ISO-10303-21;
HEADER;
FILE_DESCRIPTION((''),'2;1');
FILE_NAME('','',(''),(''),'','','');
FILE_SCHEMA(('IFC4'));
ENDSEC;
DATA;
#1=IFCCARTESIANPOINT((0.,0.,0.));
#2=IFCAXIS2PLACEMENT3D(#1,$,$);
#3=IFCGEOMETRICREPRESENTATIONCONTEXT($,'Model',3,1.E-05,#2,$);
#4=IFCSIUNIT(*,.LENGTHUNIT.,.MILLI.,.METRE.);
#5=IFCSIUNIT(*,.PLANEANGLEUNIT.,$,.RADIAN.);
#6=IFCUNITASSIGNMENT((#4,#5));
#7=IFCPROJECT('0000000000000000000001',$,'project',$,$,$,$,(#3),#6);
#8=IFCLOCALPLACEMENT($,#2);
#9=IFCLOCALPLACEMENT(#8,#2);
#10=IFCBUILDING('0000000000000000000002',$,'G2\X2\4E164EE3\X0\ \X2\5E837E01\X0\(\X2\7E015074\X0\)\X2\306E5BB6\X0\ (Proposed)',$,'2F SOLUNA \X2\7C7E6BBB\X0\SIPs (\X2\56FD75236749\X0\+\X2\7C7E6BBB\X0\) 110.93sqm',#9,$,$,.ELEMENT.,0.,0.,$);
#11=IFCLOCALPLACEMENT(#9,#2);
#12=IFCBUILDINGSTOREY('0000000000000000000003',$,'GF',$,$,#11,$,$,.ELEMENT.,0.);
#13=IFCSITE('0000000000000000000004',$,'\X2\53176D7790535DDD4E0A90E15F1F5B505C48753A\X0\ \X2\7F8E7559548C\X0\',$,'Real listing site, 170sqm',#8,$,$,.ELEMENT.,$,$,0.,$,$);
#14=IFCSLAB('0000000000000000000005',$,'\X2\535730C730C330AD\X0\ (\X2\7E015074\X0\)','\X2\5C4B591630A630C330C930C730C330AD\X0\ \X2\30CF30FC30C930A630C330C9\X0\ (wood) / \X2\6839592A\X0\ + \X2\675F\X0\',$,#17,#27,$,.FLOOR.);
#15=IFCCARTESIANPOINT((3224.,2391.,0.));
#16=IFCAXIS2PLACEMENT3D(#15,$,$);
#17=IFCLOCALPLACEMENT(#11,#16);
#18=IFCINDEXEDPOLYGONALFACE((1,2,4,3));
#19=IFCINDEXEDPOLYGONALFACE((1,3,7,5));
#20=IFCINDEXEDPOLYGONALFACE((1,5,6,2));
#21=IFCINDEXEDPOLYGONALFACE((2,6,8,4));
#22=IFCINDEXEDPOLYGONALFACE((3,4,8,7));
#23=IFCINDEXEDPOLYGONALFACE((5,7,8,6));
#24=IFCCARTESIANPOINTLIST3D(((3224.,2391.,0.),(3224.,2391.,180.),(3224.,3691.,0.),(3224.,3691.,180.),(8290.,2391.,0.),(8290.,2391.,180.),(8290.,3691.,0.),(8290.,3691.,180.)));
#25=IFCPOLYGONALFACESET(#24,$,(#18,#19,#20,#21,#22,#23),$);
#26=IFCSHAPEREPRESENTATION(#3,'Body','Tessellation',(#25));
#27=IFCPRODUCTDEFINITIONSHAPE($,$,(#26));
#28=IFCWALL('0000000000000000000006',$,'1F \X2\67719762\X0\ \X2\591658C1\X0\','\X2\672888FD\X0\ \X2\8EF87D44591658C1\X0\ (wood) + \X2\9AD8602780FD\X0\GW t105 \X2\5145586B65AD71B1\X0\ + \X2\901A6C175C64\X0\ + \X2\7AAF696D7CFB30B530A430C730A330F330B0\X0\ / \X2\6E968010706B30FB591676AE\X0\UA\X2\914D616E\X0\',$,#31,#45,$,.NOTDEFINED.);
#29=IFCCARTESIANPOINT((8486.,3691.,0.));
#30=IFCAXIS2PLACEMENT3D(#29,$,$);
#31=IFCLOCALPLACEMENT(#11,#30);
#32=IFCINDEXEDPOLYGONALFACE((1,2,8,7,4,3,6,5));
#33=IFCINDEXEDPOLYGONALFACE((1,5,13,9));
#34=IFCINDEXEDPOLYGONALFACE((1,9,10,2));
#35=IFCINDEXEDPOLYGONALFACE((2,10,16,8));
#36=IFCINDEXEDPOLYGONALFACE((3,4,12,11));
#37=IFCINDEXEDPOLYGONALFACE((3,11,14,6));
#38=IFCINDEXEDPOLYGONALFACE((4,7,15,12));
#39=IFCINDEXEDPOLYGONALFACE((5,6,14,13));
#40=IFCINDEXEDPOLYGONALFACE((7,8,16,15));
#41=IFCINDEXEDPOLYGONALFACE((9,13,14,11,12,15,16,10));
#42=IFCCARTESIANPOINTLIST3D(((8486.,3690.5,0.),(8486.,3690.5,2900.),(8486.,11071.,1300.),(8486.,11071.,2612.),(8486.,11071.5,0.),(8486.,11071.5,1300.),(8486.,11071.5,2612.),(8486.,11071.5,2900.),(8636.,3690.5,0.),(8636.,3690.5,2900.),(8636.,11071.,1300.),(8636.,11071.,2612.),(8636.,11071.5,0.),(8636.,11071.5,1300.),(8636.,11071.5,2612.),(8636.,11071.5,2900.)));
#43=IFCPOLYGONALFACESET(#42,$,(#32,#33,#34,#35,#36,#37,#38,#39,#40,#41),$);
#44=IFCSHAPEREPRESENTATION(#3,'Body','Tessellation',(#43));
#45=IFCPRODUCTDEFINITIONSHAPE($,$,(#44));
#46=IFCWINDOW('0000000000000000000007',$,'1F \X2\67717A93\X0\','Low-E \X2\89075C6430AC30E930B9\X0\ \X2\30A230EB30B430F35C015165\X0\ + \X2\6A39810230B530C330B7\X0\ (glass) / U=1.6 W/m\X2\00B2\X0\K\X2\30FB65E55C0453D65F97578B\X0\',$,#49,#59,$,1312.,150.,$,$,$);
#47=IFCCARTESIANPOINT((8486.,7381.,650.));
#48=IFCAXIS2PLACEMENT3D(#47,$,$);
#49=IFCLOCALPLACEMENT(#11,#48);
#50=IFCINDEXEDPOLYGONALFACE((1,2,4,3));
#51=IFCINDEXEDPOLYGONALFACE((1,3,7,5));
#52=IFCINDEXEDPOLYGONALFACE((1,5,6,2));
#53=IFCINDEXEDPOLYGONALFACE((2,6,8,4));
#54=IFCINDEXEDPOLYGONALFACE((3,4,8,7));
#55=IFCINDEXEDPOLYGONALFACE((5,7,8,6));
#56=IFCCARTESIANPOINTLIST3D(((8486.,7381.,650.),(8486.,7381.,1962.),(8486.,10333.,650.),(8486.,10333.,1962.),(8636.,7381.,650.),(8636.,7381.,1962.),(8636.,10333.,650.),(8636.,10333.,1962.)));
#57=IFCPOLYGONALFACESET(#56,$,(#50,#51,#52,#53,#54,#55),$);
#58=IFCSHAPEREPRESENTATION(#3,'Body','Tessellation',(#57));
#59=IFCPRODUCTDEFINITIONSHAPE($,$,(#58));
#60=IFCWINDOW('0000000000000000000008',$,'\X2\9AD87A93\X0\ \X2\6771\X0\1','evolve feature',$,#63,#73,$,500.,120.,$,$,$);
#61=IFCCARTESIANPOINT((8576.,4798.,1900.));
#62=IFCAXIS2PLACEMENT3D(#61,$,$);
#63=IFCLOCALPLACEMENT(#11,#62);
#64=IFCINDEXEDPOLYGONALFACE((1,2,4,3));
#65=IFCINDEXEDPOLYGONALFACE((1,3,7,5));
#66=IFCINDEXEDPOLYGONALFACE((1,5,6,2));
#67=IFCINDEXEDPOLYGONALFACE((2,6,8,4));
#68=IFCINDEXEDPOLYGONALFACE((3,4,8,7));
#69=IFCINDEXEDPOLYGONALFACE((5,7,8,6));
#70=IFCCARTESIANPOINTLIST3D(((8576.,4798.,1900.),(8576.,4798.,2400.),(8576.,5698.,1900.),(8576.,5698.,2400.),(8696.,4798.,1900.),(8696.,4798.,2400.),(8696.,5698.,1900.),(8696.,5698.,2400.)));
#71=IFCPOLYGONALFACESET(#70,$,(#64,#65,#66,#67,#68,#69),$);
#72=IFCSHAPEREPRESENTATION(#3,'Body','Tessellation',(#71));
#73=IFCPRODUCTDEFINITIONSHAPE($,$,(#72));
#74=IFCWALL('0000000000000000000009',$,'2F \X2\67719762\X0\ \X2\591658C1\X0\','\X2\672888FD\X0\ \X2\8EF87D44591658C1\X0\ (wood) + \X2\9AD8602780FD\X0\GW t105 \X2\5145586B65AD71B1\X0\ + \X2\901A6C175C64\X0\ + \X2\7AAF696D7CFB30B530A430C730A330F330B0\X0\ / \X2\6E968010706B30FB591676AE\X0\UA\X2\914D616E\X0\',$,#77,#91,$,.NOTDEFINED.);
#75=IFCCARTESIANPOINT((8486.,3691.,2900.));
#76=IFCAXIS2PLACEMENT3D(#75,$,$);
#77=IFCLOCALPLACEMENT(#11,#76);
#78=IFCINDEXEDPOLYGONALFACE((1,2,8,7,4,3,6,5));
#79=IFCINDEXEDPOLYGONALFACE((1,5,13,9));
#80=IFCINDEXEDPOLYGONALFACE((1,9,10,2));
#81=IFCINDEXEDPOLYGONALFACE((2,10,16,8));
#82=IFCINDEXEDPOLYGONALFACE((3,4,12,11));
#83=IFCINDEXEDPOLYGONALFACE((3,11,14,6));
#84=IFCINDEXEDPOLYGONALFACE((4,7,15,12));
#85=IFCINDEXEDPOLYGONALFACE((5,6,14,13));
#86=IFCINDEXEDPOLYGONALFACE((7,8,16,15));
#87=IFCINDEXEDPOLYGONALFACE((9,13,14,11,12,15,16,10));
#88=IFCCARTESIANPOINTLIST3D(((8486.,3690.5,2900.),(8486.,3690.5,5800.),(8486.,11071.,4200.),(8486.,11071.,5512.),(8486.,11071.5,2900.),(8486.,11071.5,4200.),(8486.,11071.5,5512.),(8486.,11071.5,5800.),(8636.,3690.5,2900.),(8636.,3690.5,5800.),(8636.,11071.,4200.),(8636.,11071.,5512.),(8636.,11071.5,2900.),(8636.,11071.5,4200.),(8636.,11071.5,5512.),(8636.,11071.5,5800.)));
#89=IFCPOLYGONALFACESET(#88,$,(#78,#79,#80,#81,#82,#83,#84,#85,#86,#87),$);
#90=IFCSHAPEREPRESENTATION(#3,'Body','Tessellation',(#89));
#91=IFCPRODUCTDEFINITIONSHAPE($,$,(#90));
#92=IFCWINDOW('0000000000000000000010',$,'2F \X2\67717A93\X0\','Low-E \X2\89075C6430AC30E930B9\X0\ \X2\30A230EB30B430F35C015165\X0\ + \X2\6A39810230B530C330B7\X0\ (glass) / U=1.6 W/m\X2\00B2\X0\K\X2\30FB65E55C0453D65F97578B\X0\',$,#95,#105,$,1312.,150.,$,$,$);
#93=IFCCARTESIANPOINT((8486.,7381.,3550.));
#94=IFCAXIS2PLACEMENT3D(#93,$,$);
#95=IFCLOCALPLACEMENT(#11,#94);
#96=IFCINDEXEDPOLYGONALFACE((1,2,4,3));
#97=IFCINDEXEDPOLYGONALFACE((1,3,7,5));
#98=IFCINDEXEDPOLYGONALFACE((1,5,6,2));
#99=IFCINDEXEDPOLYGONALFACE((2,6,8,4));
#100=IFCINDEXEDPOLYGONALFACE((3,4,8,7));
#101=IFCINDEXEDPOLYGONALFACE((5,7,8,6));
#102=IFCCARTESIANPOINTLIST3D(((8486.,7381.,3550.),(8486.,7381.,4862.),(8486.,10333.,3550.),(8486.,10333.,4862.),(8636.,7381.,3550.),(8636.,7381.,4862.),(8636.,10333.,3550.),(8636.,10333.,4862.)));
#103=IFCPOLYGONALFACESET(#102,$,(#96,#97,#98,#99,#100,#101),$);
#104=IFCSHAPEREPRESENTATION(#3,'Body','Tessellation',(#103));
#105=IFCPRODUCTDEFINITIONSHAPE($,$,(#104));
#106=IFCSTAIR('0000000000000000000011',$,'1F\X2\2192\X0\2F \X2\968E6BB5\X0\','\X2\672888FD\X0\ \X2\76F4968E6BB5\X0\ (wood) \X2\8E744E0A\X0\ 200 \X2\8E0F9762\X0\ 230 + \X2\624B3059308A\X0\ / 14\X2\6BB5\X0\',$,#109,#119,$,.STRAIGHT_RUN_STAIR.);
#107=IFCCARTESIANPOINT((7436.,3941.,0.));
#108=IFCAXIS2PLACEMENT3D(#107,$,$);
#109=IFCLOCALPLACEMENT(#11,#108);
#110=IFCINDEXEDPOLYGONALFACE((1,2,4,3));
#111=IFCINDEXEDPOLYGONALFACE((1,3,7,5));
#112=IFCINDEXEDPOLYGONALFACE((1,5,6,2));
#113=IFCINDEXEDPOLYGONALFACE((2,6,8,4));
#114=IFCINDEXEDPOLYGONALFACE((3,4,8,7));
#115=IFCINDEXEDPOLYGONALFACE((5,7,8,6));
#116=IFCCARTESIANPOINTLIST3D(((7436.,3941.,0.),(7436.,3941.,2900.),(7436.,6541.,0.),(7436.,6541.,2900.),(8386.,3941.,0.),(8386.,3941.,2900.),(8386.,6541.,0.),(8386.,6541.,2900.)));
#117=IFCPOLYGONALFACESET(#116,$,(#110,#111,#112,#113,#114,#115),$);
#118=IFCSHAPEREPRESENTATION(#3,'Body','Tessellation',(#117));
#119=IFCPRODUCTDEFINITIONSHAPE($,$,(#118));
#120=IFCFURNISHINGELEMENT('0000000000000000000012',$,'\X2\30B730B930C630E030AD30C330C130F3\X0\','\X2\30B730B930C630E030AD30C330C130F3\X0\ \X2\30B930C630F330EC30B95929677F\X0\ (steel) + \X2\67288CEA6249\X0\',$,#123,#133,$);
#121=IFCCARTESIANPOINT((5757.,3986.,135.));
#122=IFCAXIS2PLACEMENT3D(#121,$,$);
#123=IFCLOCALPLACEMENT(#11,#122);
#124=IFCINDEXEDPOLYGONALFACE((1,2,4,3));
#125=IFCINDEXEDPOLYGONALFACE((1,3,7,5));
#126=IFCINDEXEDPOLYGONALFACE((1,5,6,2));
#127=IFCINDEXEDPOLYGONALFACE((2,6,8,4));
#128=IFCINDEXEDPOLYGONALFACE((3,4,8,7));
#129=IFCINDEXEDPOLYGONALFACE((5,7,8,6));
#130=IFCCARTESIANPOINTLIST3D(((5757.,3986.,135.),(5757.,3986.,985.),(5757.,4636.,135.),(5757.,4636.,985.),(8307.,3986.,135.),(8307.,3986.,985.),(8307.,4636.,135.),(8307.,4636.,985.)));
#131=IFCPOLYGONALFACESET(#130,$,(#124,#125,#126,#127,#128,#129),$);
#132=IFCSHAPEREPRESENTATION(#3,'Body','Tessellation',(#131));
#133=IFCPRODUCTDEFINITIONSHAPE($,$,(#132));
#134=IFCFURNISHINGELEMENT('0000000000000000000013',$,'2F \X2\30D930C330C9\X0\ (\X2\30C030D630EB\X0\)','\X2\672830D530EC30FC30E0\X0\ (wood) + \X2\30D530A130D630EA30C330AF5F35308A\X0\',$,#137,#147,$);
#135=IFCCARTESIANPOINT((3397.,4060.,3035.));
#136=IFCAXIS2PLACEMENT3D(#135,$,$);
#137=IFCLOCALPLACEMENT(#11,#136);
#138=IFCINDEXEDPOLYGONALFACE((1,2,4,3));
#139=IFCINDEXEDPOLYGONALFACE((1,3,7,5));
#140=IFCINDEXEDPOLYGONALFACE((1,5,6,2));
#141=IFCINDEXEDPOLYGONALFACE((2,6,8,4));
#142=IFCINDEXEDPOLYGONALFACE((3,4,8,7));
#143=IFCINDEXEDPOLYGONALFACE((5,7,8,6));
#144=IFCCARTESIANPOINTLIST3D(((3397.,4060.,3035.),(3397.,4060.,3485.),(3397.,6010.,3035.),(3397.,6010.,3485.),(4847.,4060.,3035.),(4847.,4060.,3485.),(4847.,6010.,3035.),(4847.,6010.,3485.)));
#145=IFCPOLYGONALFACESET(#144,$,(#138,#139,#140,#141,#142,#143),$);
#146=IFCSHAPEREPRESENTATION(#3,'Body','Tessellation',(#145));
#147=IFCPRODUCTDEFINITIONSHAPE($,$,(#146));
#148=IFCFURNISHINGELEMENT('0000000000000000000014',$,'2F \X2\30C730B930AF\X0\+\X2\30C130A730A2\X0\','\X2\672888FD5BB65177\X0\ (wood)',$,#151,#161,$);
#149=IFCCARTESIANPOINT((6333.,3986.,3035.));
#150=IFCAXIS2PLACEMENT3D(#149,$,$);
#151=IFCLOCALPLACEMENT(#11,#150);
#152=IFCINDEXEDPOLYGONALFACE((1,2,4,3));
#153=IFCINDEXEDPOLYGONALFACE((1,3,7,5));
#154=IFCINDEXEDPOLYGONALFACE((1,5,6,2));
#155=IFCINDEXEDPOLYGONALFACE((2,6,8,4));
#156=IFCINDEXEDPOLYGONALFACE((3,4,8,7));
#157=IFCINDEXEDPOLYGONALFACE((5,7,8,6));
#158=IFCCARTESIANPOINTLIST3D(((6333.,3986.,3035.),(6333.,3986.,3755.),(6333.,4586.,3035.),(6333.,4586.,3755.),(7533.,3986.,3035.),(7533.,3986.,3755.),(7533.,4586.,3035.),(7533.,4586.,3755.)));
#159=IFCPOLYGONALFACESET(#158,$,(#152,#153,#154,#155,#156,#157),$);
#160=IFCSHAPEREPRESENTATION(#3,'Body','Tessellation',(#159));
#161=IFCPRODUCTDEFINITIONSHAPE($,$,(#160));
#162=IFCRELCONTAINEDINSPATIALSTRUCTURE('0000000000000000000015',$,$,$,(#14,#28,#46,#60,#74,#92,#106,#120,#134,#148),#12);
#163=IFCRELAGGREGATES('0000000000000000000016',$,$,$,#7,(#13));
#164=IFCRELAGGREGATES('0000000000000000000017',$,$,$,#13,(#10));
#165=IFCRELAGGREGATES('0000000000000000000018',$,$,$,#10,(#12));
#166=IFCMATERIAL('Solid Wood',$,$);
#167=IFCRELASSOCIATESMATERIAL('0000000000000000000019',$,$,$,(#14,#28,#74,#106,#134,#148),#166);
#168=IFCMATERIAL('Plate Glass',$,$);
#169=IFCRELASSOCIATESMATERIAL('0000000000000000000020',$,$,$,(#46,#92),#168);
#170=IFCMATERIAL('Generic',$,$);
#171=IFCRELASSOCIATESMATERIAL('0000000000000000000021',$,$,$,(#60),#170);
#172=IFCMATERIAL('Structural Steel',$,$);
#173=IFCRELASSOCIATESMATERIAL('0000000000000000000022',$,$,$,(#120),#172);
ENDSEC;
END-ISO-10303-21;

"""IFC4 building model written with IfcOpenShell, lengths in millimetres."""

from ifc_helpers import new_model, si_unit, frame, frame_2d, origin, place, context, project, spatial, rectangle, extrude, material, element, fill, save


model = new_model("IFC4")

# Units and contexts
model_context = context("Model", 3, precision=1e-05, world=origin())
ifc_project = project(units=[si_unit("LENGTHUNIT", "METRE", prefix="MILLI"), si_unit("PLANEANGLEUNIT", "RADIAN")], contexts=[model_context])

# Site, building, storey
site_placement = place(None, origin())
site = spatial("IfcSite", under=ifc_project, at=site_placement, Name="北海道川上郡弟子屈町 美留和", ObjectType="Real listing site, 170sqm", CompositionType="ELEMENT", RefElevation=0.0)
building_placement = place(site_placement, origin())
building = spatial("IfcBuilding", under=site, at=building_placement, Name="G2世代 広縁(縁側)の家 (Proposed)", ObjectType="2F SOLUNA 籾殻SIPs (国産杉+籾殻) 110.93sqm", CompositionType="ELEMENT", ElevationOfRefHeight=0.0, ElevationOfTerrain=0.0)
storey_placement = place(building_placement, origin())
storey = spatial("IfcBuildingStorey", under=building, at=storey_placement, Name="GF", CompositionType="ELEMENT", Elevation=0.0)

# Slab
ifc_material_1 = material(Name="Solid Wood")
slab_placement = place(storey_placement, frame((3224.0, 2391.0, 0.0)))
element("IfcSlab", 1, at=slab_placement, inside=storey, material=ifc_material_1, Name="南デッキ (縁側)", Description="屋外ウッドデッキ ハードウッド (wood) / 根太 + 束", PredefinedType="FLOOR", context=model_context, shape_type="SweptSolid", body=[
    extrude(rectangle(XDim=5066.0, YDim=1300.0, at=frame_2d((2533.0, 650.0))), frame((3224.0, 2391.0, 0.0)), (0.0, 0.0, 1.0), 180.0),
])

# Wall, openings, windows
wall_1_placement = place(storey_placement, frame((8486.0, 3691.0, 0.0)))
wall_1 = element("IfcWall", 2, at=wall_1_placement, inside=storey, material=ifc_material_1, Name="1F 東面 外壁", Description="木製 軸組外壁 (wood) + 高性能GW t105 充填断熱 + 通気層 + 窯業系サイディング / 準耐火・外皮UA配慮", PredefinedType="NOTDEFINED", context=model_context, shape_type="SweptSolid", body=[
    extrude(rectangle(XDim=150.0, YDim=7381.0, at=frame_2d((75.0, 3690.0))), frame((8486.0, 3691.0, 0.0)), (0.0, 0.0, 1.0), 2900.0),
])
opening_1_placement = place(storey_placement, frame((8486.0, 7381.0, 650.0)))
opening_1 = element("IfcOpeningElement", 3, at=opening_1_placement, cuts=wall_1, PredefinedType="NOTDEFINED", context=model_context, shape_type="SweptSolid", body=[
    extrude(rectangle(XDim=150.0, YDim=2952.0, at=frame_2d((75.0, 1476.0))), frame((8486.0, 7381.0, 650.0)), (0.0, 0.0, 1.0), 1312.0),
])
opening_2_placement = place(storey_placement, frame((8576.0, 4798.0, 1900.0)))
opening_2 = element("IfcOpeningElement", 4, at=opening_2_placement, cuts=wall_1, PredefinedType="NOTDEFINED", context=model_context, shape_type="SweptSolid", body=[
    extrude(rectangle(XDim=120.0, YDim=900.0, at=frame_2d((60.0, 450.0))), frame((8576.0, 4798.0, 1900.0)), (0.0, 0.0, 1.0), 500.0),
])
ifc_material_2 = material(Name="Plate Glass")
window_1_placement = place(storey_placement, frame((8486.0, 7381.0, 650.0)))
window_1 = element("IfcWindow", 5, at=window_1_placement, inside=storey, material=ifc_material_2, Name="1F 東窓", Description="Low-E 複層ガラス アルゴン封入 + 樹脂サッシ (glass) / U=1.6 W/m²K・日射取得型", OverallHeight=1312.0, OverallWidth=150.0, context=model_context, shape_type="SweptSolid", body=[
    extrude(rectangle(XDim=150.0, YDim=2952.0, at=frame_2d((75.0, 1476.0))), frame((8486.0, 7381.0, 650.0)), (0.0, 0.0, 1.0), 1312.0),
])
fill(opening_1, window_1)
ifc_material_3 = material(Name="Generic")
window_2_placement = place(storey_placement, frame((8576.0, 4798.0, 1900.0)))
window_2 = element("IfcWindow", 6, at=window_2_placement, inside=storey, material=ifc_material_3, Name="高窓 東1", Description="evolve feature", OverallHeight=500.0, OverallWidth=120.0, context=model_context, shape_type="SweptSolid", body=[
    extrude(rectangle(XDim=120.0, YDim=900.0, at=frame_2d((60.0, 450.0))), frame((8576.0, 4798.0, 1900.0)), (0.0, 0.0, 1.0), 500.0),
])
fill(opening_2, window_2)

# Wall, opening, window
wall_2_placement = place(storey_placement, frame((8486.0, 3691.0, 2900.0)))
wall_2 = element("IfcWall", 7, at=wall_2_placement, inside=storey, material=ifc_material_1, Name="2F 東面 外壁", Description="木製 軸組外壁 (wood) + 高性能GW t105 充填断熱 + 通気層 + 窯業系サイディング / 準耐火・外皮UA配慮", PredefinedType="NOTDEFINED", context=model_context, shape_type="SweptSolid", body=[
    extrude(rectangle(XDim=150.0, YDim=7381.0, at=frame_2d((75.0, 3690.0))), frame((8486.0, 3691.0, 2900.0)), (0.0, 0.0, 1.0), 2900.0),
])
opening_3_placement = place(storey_placement, frame((8486.0, 7381.0, 3550.0)))
opening_3 = element("IfcOpeningElement", 8, at=opening_3_placement, cuts=wall_2, PredefinedType="NOTDEFINED", context=model_context, shape_type="SweptSolid", body=[
    extrude(rectangle(XDim=150.0, YDim=2952.0, at=frame_2d((75.0, 1476.0))), frame((8486.0, 7381.0, 3550.0)), (0.0, 0.0, 1.0), 1312.0),
])
window_3_placement = place(storey_placement, frame((8486.0, 7381.0, 3550.0)))
window_3 = element("IfcWindow", 9, at=window_3_placement, inside=storey, material=ifc_material_2, Name="2F 東窓", Description="Low-E 複層ガラス アルゴン封入 + 樹脂サッシ (glass) / U=1.6 W/m²K・日射取得型", OverallHeight=1312.0, OverallWidth=150.0, context=model_context, shape_type="SweptSolid", body=[
    extrude(rectangle(XDim=150.0, YDim=2952.0, at=frame_2d((75.0, 1476.0))), frame((8486.0, 7381.0, 3550.0)), (0.0, 0.0, 1.0), 1312.0),
])
fill(opening_3, window_3)

# Stair
stair_placement = place(storey_placement, frame((7436.0, 3941.0, 0.0)))
element("IfcStair", 10, at=stair_placement, inside=storey, material=ifc_material_1, Name="1F→2F 階段", Description="木製 直階段 (wood) 蹴上 200 踏面 230 + 手すり / 14段", PredefinedType="STRAIGHT_RUN_STAIR", context=model_context, shape_type="SweptSolid", body=[
    extrude(rectangle(XDim=950.0, YDim=2600.0, at=frame_2d((475.0, 1300.0))), frame((7436.0, 3941.0, 0.0)), (0.0, 0.0, 1.0), 2900.0),
])

# Furnishing elements
ifc_material_4 = material(Name="Structural Steel")
furnishing_1_placement = place(storey_placement, frame((5757.0, 3986.0, 135.0)))
element("IfcFurnishingElement", 11, at=furnishing_1_placement, inside=storey, material=ifc_material_4, Name="システムキッチン", Description="システムキッチン ステンレス天板 (steel) + 木質扉", context=model_context, shape_type="SweptSolid", body=[
    extrude(rectangle(XDim=2550.0, YDim=650.0, at=frame_2d((1275.0, 325.0))), frame((5757.0, 3986.0, 135.0)), (0.0, 0.0, 1.0), 850.0),
])
furnishing_2_placement = place(storey_placement, frame((3397.0, 4060.0, 3035.0)))
element("IfcFurnishingElement", 12, at=furnishing_2_placement, inside=storey, material=ifc_material_1, Name="2F ベッド (ダブル)", Description="木フレーム (wood) + ファブリック張り", context=model_context, shape_type="SweptSolid", body=[
    extrude(rectangle(XDim=1450.0, YDim=1950.0, at=frame_2d((725.0, 975.0))), frame((3397.0, 4060.0, 3035.0)), (0.0, 0.0, 1.0), 450.0),
])
furnishing_3_placement = place(storey_placement, frame((6333.0, 3986.0, 3035.0)))
element("IfcFurnishingElement", 13, at=furnishing_3_placement, inside=storey, material=ifc_material_1, Name="2F デスク+チェア", Description="木製家具 (wood)", context=model_context, shape_type="SweptSolid", body=[
    extrude(rectangle(XDim=1200.0, YDim=600.0, at=frame_2d((600.0, 300.0))), frame((6333.0, 3986.0, 3035.0)), (0.0, 0.0, 1.0), 720.0),
])

save(model, "model.ifc")
